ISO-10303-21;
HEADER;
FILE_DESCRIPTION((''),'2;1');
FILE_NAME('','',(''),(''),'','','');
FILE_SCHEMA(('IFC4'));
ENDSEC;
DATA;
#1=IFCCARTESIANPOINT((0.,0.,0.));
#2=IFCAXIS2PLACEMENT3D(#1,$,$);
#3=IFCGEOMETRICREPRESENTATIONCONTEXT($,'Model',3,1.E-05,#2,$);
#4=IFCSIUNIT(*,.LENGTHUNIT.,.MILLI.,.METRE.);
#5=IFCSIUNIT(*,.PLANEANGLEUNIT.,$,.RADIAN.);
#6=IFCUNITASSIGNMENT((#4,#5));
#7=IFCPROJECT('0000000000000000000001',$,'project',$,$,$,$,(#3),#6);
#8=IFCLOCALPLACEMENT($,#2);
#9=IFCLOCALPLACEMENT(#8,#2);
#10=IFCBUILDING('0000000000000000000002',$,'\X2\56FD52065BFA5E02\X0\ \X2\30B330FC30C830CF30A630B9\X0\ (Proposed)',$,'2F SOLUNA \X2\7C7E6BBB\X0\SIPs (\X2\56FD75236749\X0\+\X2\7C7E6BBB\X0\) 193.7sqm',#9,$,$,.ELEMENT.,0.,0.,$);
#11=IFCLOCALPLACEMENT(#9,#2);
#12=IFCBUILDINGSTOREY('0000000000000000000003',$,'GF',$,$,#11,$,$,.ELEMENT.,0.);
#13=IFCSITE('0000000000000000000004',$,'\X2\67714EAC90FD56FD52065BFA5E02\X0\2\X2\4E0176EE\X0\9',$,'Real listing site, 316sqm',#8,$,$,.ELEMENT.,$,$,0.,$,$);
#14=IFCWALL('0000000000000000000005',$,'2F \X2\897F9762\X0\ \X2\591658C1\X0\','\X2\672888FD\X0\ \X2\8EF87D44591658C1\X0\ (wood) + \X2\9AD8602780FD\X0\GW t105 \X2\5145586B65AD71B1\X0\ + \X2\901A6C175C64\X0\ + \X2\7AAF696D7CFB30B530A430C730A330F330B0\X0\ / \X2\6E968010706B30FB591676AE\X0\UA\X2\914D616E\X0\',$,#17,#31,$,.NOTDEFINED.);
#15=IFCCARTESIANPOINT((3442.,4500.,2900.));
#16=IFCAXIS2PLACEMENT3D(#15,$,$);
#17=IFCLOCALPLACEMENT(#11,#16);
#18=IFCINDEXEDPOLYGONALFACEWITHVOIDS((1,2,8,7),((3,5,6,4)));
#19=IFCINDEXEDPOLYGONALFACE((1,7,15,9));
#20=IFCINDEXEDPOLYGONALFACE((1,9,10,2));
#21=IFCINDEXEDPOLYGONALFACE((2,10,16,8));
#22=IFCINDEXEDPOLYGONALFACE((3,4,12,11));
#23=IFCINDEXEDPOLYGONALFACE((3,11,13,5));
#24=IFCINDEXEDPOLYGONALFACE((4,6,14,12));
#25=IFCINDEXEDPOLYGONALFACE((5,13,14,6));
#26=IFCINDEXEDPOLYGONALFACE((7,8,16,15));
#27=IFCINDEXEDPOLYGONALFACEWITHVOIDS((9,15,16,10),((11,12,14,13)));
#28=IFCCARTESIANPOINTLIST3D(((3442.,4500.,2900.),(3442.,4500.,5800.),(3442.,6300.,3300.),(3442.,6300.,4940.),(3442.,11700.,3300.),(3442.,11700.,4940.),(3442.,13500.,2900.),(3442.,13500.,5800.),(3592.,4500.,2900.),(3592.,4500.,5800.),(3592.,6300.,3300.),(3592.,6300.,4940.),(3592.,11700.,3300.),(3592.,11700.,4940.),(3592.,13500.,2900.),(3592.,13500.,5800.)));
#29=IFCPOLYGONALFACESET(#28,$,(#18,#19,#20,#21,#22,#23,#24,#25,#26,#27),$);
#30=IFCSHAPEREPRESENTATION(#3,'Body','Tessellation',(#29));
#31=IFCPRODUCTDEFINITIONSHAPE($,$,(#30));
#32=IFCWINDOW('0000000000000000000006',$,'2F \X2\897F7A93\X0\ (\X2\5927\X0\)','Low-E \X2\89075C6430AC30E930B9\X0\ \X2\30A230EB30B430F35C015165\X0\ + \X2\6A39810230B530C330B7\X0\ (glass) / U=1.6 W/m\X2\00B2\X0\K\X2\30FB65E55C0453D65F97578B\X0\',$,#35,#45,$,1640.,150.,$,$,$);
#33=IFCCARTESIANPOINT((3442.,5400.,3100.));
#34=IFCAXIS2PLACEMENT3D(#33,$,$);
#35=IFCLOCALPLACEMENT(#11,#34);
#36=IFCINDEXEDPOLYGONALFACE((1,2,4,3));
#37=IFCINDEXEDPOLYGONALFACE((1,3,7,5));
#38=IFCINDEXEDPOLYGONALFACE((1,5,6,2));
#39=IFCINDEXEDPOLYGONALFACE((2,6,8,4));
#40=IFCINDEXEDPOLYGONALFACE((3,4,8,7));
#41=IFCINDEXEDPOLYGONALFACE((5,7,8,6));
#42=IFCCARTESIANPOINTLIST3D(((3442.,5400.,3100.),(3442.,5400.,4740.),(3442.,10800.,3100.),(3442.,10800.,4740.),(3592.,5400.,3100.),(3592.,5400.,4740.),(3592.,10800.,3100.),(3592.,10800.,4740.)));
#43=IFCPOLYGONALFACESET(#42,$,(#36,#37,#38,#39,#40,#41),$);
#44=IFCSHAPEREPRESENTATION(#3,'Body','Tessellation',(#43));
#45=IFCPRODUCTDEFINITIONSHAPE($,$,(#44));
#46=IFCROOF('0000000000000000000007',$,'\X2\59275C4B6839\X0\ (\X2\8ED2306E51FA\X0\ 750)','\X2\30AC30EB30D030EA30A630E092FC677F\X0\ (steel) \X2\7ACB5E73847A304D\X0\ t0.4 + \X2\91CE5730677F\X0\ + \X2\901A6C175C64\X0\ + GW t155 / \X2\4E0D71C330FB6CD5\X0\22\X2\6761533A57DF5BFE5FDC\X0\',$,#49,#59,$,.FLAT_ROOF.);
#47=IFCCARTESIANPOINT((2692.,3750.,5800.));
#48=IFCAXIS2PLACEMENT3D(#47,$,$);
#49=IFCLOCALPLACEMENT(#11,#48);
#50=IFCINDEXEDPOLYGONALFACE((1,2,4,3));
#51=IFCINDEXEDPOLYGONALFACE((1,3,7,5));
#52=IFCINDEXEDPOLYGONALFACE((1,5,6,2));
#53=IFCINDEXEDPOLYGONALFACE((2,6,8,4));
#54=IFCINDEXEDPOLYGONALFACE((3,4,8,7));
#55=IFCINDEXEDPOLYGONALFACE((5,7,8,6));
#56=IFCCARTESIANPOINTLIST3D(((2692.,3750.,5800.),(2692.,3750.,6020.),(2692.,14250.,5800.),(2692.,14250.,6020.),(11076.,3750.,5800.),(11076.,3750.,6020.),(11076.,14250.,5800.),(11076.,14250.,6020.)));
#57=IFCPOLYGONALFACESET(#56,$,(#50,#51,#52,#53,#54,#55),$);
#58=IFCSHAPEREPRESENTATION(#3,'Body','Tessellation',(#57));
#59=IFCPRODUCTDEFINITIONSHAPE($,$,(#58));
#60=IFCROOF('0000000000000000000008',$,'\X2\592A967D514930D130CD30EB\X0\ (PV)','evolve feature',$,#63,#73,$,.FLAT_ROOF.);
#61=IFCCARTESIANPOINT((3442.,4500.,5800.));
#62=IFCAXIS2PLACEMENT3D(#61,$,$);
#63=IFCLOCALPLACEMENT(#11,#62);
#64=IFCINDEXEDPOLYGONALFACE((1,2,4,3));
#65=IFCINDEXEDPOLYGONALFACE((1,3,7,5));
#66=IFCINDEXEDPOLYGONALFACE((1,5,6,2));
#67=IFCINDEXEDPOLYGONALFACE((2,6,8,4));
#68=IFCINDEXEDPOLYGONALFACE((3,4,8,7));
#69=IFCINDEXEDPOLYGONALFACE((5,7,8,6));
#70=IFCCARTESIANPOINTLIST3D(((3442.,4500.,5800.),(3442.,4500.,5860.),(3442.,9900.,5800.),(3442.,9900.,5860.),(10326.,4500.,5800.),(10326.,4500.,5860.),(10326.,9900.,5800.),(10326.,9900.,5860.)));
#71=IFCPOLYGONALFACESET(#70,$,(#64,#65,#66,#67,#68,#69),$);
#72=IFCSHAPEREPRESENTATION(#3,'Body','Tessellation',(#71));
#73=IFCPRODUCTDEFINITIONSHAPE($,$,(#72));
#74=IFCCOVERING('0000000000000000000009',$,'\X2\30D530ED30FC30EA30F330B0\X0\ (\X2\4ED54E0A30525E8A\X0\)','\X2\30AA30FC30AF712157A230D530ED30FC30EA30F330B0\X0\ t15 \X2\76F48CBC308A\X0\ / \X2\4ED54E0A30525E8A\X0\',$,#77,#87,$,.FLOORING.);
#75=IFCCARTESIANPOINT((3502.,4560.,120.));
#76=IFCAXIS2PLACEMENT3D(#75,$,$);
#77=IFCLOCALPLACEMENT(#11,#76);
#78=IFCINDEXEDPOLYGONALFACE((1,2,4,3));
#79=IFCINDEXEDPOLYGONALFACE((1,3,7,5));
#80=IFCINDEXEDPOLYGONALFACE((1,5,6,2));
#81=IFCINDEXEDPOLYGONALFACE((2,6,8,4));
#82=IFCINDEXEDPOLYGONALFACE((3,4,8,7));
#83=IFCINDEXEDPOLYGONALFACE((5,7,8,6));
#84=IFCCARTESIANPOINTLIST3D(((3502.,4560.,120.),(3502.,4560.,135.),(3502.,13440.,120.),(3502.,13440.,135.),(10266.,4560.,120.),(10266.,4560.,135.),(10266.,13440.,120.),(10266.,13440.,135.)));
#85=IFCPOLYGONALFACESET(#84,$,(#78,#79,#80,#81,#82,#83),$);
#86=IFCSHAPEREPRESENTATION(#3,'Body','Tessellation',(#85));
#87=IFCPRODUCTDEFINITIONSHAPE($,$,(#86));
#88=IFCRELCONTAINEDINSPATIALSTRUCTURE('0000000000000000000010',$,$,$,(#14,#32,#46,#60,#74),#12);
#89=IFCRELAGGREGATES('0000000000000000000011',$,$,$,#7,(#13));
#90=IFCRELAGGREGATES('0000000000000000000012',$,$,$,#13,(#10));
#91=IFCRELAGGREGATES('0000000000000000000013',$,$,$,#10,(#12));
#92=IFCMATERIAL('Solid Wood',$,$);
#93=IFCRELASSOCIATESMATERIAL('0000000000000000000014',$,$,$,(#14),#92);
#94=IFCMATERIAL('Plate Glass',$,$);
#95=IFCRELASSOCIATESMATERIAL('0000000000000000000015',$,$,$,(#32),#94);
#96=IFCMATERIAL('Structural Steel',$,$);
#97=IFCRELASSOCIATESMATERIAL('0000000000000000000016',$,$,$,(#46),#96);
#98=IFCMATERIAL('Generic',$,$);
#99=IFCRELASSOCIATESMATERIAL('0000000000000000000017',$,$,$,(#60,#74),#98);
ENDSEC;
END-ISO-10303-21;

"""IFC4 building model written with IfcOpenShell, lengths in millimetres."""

from ifc_helpers import new_model, si_unit, frame, frame_2d, origin, place, context, project, spatial, rectangle, extrude, material, element, fill, save


model = new_model("IFC4")

# Units and contexts
model_context = context("Model", 3, precision=1e-05, world=origin())
ifc_project = project(units=[si_unit("LENGTHUNIT", "METRE", prefix="MILLI"), si_unit("PLANEANGLEUNIT", "RADIAN")], contexts=[model_context])

# Site, building, storey
site_placement = place(None, origin())
site = spatial("IfcSite", under=ifc_project, at=site_placement, Name="東京都国分寺市2丁目9", ObjectType="Real listing site, 316sqm", CompositionType="ELEMENT", RefElevation=0.0)
building_placement = place(site_placement, origin())
building = spatial("IfcBuilding", under=site, at=building_placement, Name="国分寺市 コートハウス (Proposed)", ObjectType="2F SOLUNA 籾殻SIPs (国産杉+籾殻) 193.7sqm", CompositionType="ELEMENT", ElevationOfRefHeight=0.0, ElevationOfTerrain=0.0)
storey_placement = place(building_placement, origin())
storey = spatial("IfcBuildingStorey", under=building, at=storey_placement, Name="GF", CompositionType="ELEMENT", Elevation=0.0)

# Shared definitions
ifc_material_1 = material(Name="Solid Wood")

# Shared definitions
ifc_material_2 = material(Name="Plate Glass")
ifc_material_3 = material(Name="Generic")

# Wall, opening, window
wall_1_placement = place(storey_placement, frame((3442.0, 4500.0, 2900.0)))
wall_1 = element("IfcWall", 1, at=wall_1_placement, inside=storey, material=ifc_material_1, Name="2F 西面 外壁", Description="木製 軸組外壁 (wood) + 高性能GW t105 充填断熱 + 通気層 + 窯業系サイディング / 準耐火・外皮UA配慮", PredefinedType="NOTDEFINED", context=model_context, shape_type="SweptSolid", body=[
    extrude(rectangle(XDim=150.0, YDim=9000.0, at=frame_2d((75.0, 4500.0))), frame((3442.0, 4500.0, 2900.0)), (0.0, 0.0, 1.0), 2900.0),
])
opening_1_placement = place(storey_placement, frame((3442.0, 5400.0, 3100.0)))
opening_1 = element("IfcOpeningElement", 2, at=opening_1_placement, cuts=wall_1, PredefinedType="NOTDEFINED", context=model_context, shape_type="SweptSolid", body=[
    extrude(rectangle(XDim=150.0, YDim=5400.0, at=frame_2d((75.0, 2700.0))), frame((3442.0, 5400.0, 3100.0)), (0.0, 0.0, 1.0), 1640.0),
])
window_1_placement = place(storey_placement, frame((3442.0, 5400.0, 3100.0)))
window_1 = element("IfcWindow", 3, at=window_1_placement, inside=storey, material=ifc_material_2, Name="2F 西窓 (大)", Description="Low-E 複層ガラス アルゴン封入 + 樹脂サッシ (glass) / U=1.6 W/m²K・日射取得型", OverallHeight=1640.0, OverallWidth=150.0, context=model_context, shape_type="SweptSolid", body=[
    extrude(rectangle(XDim=150.0, YDim=5400.0, at=frame_2d((75.0, 2700.0))), frame((3442.0, 5400.0, 3100.0)), (0.0, 0.0, 1.0), 1640.0),
])
fill(opening_1, window_1)

# Roofs
ifc_material_4 = material(Name="Structural Steel")
roof_1_placement = place(storey_placement, frame((2692.0, 3750.0, 5800.0)))
element("IfcRoof", 4, at=roof_1_placement, inside=storey, material=ifc_material_4, Name="大屋根 (軒の出 750)", Description="ガルバリウム鋼板 (steel) 立平葺き t0.4 + 野地板 + 通気層 + GW t155 / 不燃・法22条区域対応", PredefinedType="FLAT_ROOF", context=model_context, shape_type="SweptSolid", body=[
    extrude(rectangle(XDim=8384.0, YDim=10500.0, at=frame_2d((4192.0, 5250.0))), frame((2692.0, 3750.0, 5800.0)), (0.0, 0.0, 1.0), 220.0),
])
roof_2_placement = place(storey_placement, frame((3442.0, 4500.0, 5800.0)))
element("IfcRoof", 5, at=roof_2_placement, inside=storey, material=ifc_material_3, Name="太陽光パネル (PV)", Description="evolve feature", PredefinedType="FLAT_ROOF", context=model_context, shape_type="SweptSolid", body=[
    extrude(rectangle(XDim=6884.0, YDim=5400.0, at=frame_2d((3442.0, 2700.0))), frame((3442.0, 4500.0, 5800.0)), (0.0, 0.0, 1.0), 60.0),
])

# Covering
covering_placement = place(storey_placement, frame((3502.0, 4560.0, 120.0)))
element("IfcCovering", 6, at=covering_placement, inside=storey, material=ifc_material_3, Name="フローリング (仕上げ床)", Description="オーク無垢フローリング t15 直貼り / 仕上げ床", PredefinedType="FLOORING", context=model_context, shape_type="SweptSolid", body=[
    extrude(rectangle(XDim=6764.0, YDim=8880.0, at=frame_2d((3382.0, 4440.0))), frame((3502.0, 4560.0, 120.0)), (0.0, 0.0, 1.0), 15.0),
])

save(model, "model.ifc")
